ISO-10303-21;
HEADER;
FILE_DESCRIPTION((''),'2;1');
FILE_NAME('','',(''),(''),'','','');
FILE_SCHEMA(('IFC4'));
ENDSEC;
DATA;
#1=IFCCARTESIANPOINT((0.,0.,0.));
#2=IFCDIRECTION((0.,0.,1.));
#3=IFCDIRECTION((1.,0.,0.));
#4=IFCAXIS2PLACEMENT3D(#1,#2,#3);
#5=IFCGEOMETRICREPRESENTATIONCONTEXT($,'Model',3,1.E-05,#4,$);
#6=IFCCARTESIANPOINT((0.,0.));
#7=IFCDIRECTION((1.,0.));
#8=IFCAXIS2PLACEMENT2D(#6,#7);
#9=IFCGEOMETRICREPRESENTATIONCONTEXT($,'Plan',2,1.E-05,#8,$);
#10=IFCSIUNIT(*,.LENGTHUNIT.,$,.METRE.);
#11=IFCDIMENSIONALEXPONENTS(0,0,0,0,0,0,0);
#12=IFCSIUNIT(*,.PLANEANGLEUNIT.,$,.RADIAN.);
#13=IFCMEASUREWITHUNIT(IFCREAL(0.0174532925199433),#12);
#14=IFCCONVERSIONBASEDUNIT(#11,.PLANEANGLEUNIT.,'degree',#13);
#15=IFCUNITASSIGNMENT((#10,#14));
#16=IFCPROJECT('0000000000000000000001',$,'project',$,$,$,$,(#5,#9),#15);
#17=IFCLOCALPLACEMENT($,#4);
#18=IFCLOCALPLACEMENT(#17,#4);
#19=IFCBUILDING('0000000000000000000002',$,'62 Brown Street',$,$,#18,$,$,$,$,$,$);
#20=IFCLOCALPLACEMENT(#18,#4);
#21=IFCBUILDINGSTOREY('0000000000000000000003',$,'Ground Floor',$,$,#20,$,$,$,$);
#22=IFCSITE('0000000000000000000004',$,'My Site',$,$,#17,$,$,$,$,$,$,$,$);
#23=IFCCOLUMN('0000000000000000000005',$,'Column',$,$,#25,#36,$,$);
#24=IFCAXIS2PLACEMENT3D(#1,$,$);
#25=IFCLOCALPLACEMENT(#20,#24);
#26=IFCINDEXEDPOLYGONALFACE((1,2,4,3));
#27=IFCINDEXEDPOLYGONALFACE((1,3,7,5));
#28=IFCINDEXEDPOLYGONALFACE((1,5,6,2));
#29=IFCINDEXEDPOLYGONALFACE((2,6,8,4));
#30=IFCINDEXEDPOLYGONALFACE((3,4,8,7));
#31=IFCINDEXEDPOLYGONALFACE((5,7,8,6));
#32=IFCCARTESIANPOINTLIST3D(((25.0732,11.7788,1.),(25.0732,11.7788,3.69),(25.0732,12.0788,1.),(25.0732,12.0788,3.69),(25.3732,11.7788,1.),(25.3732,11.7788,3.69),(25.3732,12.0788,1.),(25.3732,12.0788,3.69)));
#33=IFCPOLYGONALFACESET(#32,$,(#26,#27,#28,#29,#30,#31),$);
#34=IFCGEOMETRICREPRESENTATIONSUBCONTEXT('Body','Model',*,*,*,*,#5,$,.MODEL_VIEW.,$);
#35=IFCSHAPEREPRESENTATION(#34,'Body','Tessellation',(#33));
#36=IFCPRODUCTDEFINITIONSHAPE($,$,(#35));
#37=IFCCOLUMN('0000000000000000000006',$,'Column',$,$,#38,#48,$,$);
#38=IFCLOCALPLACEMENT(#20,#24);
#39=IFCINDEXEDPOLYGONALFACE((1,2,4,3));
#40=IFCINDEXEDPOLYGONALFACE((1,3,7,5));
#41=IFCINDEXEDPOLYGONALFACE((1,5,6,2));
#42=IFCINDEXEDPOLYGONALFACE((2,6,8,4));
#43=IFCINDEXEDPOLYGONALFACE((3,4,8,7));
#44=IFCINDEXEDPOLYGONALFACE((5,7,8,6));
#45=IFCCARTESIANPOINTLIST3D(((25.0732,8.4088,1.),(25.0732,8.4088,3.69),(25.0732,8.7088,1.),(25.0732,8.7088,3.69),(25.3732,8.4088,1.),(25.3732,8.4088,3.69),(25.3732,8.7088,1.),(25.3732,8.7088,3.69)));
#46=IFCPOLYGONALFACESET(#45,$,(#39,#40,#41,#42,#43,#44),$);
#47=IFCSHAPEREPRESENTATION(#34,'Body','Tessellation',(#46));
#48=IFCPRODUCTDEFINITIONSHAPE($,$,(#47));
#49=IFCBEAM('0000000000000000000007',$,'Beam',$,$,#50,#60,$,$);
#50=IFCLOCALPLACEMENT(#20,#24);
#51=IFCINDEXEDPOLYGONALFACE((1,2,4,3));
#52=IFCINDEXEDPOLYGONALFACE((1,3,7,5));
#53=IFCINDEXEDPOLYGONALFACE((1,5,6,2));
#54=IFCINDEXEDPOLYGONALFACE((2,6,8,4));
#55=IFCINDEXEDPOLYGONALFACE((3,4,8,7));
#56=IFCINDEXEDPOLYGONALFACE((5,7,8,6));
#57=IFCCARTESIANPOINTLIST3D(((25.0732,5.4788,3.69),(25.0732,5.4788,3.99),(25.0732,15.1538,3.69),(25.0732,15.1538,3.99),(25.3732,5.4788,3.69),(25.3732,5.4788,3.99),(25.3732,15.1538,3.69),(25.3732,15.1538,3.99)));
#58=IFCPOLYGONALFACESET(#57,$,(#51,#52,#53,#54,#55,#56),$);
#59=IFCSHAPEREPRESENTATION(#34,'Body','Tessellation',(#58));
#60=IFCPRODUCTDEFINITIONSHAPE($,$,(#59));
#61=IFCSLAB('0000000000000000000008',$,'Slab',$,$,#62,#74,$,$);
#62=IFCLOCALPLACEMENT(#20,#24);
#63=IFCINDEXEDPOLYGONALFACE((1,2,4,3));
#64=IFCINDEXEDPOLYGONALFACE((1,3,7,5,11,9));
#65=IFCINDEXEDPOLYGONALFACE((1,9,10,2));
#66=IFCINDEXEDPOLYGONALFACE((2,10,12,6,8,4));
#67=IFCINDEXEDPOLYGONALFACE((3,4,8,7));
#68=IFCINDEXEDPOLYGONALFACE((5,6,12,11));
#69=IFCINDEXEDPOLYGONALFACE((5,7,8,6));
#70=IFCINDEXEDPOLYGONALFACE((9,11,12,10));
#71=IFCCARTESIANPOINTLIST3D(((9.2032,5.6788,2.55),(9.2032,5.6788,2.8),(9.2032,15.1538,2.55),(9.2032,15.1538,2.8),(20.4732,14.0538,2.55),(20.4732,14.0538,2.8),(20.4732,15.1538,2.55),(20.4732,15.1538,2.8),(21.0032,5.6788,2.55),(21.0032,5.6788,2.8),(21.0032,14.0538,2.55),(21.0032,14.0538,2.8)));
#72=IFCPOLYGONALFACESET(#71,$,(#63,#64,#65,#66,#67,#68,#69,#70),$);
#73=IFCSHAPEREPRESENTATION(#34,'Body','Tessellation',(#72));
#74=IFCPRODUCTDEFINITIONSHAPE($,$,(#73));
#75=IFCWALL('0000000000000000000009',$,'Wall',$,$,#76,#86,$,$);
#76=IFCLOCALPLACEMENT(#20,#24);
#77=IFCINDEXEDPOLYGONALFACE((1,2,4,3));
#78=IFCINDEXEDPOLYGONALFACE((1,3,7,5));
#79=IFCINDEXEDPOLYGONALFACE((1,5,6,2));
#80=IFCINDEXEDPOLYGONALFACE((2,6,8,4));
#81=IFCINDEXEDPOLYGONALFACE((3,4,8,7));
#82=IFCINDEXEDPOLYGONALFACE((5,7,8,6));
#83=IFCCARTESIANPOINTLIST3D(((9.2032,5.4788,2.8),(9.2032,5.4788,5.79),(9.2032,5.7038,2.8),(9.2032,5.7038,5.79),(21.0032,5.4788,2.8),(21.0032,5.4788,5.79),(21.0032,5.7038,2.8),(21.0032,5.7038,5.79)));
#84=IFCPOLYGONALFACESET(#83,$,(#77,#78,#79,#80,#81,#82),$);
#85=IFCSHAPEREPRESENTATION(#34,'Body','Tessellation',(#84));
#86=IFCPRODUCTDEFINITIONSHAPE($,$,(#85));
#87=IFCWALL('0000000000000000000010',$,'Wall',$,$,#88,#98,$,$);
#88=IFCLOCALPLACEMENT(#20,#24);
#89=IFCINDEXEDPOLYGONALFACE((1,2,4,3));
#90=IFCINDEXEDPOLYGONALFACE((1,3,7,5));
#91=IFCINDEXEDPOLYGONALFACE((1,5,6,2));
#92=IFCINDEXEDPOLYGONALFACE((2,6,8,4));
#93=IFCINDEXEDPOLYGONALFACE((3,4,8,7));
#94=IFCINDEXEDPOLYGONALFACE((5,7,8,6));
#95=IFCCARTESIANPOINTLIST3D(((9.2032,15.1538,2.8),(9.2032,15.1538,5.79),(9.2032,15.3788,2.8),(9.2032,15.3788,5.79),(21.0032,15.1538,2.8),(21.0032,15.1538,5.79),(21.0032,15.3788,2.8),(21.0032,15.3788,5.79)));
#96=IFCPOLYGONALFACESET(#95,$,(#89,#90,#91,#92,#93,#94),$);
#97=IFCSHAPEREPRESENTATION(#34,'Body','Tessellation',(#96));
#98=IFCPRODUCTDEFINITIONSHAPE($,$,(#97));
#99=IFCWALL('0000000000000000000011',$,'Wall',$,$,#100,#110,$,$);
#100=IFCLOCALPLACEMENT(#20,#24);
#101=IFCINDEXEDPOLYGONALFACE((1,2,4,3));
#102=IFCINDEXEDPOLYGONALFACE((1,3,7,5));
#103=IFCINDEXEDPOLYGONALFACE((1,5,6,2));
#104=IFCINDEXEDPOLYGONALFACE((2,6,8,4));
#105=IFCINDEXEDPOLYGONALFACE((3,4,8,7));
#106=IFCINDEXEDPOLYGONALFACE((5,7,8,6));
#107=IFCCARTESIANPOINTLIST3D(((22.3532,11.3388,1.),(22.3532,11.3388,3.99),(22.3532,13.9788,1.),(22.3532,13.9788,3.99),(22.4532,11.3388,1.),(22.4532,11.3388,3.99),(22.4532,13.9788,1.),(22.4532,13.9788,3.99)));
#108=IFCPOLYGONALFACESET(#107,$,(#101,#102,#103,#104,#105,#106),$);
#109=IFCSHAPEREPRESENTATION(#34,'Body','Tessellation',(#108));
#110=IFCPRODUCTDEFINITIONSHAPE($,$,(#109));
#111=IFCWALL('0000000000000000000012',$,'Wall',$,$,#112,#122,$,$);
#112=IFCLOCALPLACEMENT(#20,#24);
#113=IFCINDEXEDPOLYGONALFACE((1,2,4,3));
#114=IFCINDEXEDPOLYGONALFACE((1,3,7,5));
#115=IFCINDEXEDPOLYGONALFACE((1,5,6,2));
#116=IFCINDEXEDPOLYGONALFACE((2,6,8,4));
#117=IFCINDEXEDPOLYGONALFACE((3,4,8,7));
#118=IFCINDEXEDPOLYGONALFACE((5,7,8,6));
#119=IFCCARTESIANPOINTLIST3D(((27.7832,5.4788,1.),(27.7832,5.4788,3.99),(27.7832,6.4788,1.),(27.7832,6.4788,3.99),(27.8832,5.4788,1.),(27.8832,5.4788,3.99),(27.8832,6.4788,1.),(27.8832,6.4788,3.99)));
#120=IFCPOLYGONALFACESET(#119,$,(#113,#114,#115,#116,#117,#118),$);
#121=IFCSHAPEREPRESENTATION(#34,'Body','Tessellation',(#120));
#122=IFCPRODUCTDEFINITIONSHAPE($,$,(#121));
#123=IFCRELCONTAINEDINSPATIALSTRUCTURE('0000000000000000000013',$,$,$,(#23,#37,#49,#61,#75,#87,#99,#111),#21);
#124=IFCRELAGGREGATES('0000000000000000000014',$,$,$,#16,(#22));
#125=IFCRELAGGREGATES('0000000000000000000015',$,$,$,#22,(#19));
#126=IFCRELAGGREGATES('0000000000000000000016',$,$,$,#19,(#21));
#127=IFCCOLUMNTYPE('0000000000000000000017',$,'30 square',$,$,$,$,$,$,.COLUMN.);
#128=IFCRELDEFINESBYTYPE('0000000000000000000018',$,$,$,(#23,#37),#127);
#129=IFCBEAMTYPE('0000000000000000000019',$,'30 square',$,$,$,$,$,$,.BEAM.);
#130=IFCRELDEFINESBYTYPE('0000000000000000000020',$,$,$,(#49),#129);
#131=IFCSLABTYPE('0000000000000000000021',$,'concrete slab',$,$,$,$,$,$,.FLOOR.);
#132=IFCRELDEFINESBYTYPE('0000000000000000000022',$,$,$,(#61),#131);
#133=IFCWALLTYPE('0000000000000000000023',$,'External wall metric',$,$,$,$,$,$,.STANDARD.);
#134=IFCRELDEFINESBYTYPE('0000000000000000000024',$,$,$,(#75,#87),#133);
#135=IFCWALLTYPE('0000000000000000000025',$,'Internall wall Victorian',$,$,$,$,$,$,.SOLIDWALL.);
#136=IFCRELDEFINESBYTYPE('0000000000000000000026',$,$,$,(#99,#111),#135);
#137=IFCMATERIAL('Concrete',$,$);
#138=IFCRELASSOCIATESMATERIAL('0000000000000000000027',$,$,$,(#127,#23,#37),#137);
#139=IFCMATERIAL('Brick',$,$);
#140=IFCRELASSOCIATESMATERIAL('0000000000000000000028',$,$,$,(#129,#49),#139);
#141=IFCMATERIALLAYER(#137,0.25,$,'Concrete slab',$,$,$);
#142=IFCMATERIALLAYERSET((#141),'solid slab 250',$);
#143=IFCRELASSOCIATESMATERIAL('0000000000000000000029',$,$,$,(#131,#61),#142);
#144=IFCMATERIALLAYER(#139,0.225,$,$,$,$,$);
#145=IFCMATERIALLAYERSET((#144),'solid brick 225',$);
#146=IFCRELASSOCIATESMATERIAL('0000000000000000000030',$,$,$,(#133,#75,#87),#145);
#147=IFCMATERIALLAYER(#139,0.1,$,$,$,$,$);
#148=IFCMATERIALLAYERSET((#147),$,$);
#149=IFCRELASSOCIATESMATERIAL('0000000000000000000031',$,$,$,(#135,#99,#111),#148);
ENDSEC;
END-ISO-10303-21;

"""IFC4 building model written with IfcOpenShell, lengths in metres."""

from ifc_helpers import new_model, entity, si_unit, converted_unit, frame, origin_with_axes, origin_2d_with_axis, place, context, subcontext, project, spatial, line, indexed_curve, rectangle, outline, extrude, material, layer, layer_set, layer_usage, material_profile, profile_set, profile_usage, type_object, element, save


model = new_model("IFC4")

# Units and contexts
model_context = context("Model", 3, precision=1e-05, world=origin_with_axes())
plan_context = context("Plan", 2, precision=1e-05, world=origin_2d_with_axis())
body_context_1 = subcontext(model_context, "Body", "Model", "MODEL_VIEW")
ifc_project = project(units=[si_unit("LENGTHUNIT", "METRE"), converted_unit("PLANEANGLEUNIT", "degree", entity("IfcReal", 0.0174532925199433), si_unit("PLANEANGLEUNIT", "RADIAN"), dimensions=[0, 0, 0, 0, 0, 0, 0])], contexts=[model_context, plan_context])

# Site, building, storey
site_placement = place(None, origin_with_axes())
site = spatial("IfcSite", under=ifc_project, at=site_placement, Name="My Site")
building_placement = place(site_placement, origin_with_axes())
building = spatial("IfcBuilding", under=site, at=building_placement, Name="62 Brown Street")
storey_placement = place(building_placement, origin_with_axes())
storey = spatial("IfcBuildingStorey", under=building, at=storey_placement, Name="Ground Floor")

# Columns
ifc_material_1 = material(Name="Concrete")
ifc_material_profile_1 = material_profile(ifc_material_1, rectangle(XDim=0.3, YDim=0.3))
ifc_profile_set_1 = profile_set([ifc_material_profile_1])
ifc_profile_usage_1 = profile_usage(ifc_profile_set_1, cardinal=5)
column_type = type_object("IfcColumnType", Name="30 square", PredefinedType="COLUMN", material=ifc_profile_set_1)
column_1_placement = place(storey_placement, frame((25.2232, 11.9288, 1.0), z_axis=(0.0, 0.0, 1.0), x_axis=(1.0, 0.0, 0.0)))
element("IfcColumn", 1, at=column_1_placement, inside=storey, type_object=column_type, material=ifc_profile_usage_1, Name="Column", context=body_context_1, shape_type="SweptSolid", body=[
    extrude(rectangle(XDim=0.3, YDim=0.3), origin_with_axes(), (0.0, 0.0, 1.0), 2.69),
])
ifc_profile_usage_2 = profile_usage(ifc_profile_set_1, cardinal=5)
column_2_placement = place(storey_placement, frame((25.2232, 8.5588, 1.0), z_axis=(0.0, 0.0, 1.0), x_axis=(1.0, 0.0, 0.0)))
element("IfcColumn", 2, at=column_2_placement, inside=storey, type_object=column_type, material=ifc_profile_usage_2, Name="Column", context=body_context_1, shape_type="SweptSolid", body=[
    extrude(rectangle(XDim=0.3, YDim=0.3), origin_with_axes(), (0.0, 0.0, 1.0), 2.69),
])

# Beam
ifc_material_2 = material(Name="Brick")
ifc_material_profile_2 = material_profile(ifc_material_2, rectangle(XDim=0.3, YDim=0.3))
ifc_profile_set_2 = profile_set([ifc_material_profile_2])
ifc_profile_usage_3 = profile_usage(ifc_profile_set_2, cardinal=5)
beam_type = type_object("IfcBeamType", Name="30 square", PredefinedType="BEAM", material=ifc_profile_set_2)
beam_placement = place(storey_placement, frame((25.2232, 5.4788, 3.84), z_axis=(0.0, 1.0, 0.0), x_axis=(-1.0, 0.0, 0.0)))
element("IfcBeam", 3, at=beam_placement, inside=storey, type_object=beam_type, material=ifc_profile_usage_3, Name="Beam", context=body_context_1, shape_type="SweptSolid", body=[
    extrude(rectangle(XDim=0.3, YDim=0.3), origin_with_axes(), (0.0, 0.0, 1.0), 9.675),
])

# Slab
ifc_layer_1 = layer(ifc_material_1, 0.25, Name="Concrete slab")
ifc_layer_set_1 = layer_set([ifc_layer_1], Name="solid slab 250")
slab_type = type_object("IfcSlabType", Name="concrete slab", PredefinedType="FLOOR", material=ifc_layer_set_1)
ifc_layer_usage_1 = layer_usage(ifc_layer_set_1, "AXIS3", "POSITIVE", 0.0)
slab_1_placement = place(storey_placement, frame((9.2032, 5.6788, 2.55), z_axis=(0.0, 0.0, 1.0), x_axis=(1.0, 0.0, 0.0)))
element("IfcSlab", 4, at=slab_1_placement, inside=storey, type_object=slab_type, material=ifc_layer_usage_1, Name="Slab", context=body_context_1, shape_type="SweptSolid", body=[
    extrude(outline(indexed_curve([(11.27, 9.475), (11.8, 0.0), (0.0, 0.0), (0.0, 9.475), (11.8, 8.375), (11.27, 8.375)], segments=[line(6, 1), line(1, 4), line(4, 3), line(3, 2), line(2, 5), line(5, 6)], self_intersect=False)), None, (0.0, 0.0, 1.0), 0.25),
])

# Walls
ifc_layer_2 = layer(ifc_material_2, 0.225)
ifc_layer_set_2 = layer_set([ifc_layer_2], Name="solid brick 225")
wall_type_1 = type_object("IfcWallType", Name="External wall metric", PredefinedType="STANDARD", material=ifc_layer_set_2)
ifc_layer_usage_2 = layer_usage(ifc_layer_set_2, "AXIS2", "POSITIVE", 0.0)
wall_1_placement = place(storey_placement, frame((9.2032, 5.4788, 2.8), z_axis=(0.0, 0.0, 1.0), x_axis=(1.0, 0.0, 0.0)))
element("IfcWall", 5, at=wall_1_placement, inside=storey, type_object=wall_type_1, material=ifc_layer_usage_2, Name="Wall", context=body_context_1, shape_type="SweptSolid", body=[
    extrude(outline(indexed_curve([(0.0, 0.0), (0.0, 0.225), (11.8, 0.225), (11.8, 0.0), (0.0, 0.0)], self_intersect=False)), origin_with_axes(), (0.0, 0.0, 1.0), 2.99),
])
ifc_layer_usage_3 = layer_usage(ifc_layer_set_2, "AXIS2", "POSITIVE", 0.0)
wall_2_placement = place(storey_placement, frame((21.0032, 15.3788, 2.8), z_axis=(0.0, 0.0, 1.0), x_axis=(-1.0, 0.0, 0.0)))
element("IfcWall", 6, at=wall_2_placement, inside=storey, type_object=wall_type_1, material=ifc_layer_usage_3, Name="Wall", context=body_context_1, shape_type="SweptSolid", body=[
    extrude(outline(indexed_curve([(0.0, 0.0), (0.0, 0.225), (11.8, 0.225), (11.8, 0.0), (0.0, 0.0)], self_intersect=False)), origin_with_axes(), (0.0, 0.0, 1.0), 2.99),
])

# Walls
ifc_layer_3 = layer(ifc_material_2, 0.1)
ifc_layer_set_3 = layer_set([ifc_layer_3])
ifc_layer_usage_4 = layer_usage(ifc_layer_set_3, "AXIS2", "POSITIVE", 0.0)
wall_type_2 = type_object("IfcWallType", Name="Internall wall Victorian", PredefinedType="SOLIDWALL", material=ifc_layer_set_3)
wall_3_placement = place(storey_placement, frame((22.4532, 11.3388, 1.0), z_axis=(0.0, 0.0, 1.0), x_axis=(0.0, 1.0, 0.0)))
element("IfcWall", 7, at=wall_3_placement, inside=storey, type_object=wall_type_2, material=ifc_layer_usage_4, Name="Wall", context=body_context_1, shape_type="SweptSolid", body=[
    extrude(outline(indexed_curve([(0.0, 0.0), (0.0, 0.1), (2.64, 0.1), (2.64, 0.0), (0.0, 0.0)], self_intersect=False)), origin_with_axes(), (0.0, 0.0, 1.0), 2.99),
])
ifc_layer_usage_5 = layer_usage(ifc_layer_set_3, "AXIS2", "POSITIVE", 0.0)
wall_4_placement = place(storey_placement, frame((27.8832, 5.4788, 1.0), z_axis=(0.0, 0.0, 1.0), x_axis=(0.0, 1.0, 0.0)))
element("IfcWall", 8, at=wall_4_placement, inside=storey, type_object=wall_type_2, material=ifc_layer_usage_5, Name="Wall", context=body_context_1, shape_type="SweptSolid", body=[
    extrude(outline(indexed_curve([(0.0, 0.0), (0.0, 0.1), (1.0, 0.1), (1.0, 0.0), (0.0, 0.0)], self_intersect=False)), origin_with_axes(), (0.0, 0.0, 1.0), 2.99),
])

save(model, "model.ifc")
